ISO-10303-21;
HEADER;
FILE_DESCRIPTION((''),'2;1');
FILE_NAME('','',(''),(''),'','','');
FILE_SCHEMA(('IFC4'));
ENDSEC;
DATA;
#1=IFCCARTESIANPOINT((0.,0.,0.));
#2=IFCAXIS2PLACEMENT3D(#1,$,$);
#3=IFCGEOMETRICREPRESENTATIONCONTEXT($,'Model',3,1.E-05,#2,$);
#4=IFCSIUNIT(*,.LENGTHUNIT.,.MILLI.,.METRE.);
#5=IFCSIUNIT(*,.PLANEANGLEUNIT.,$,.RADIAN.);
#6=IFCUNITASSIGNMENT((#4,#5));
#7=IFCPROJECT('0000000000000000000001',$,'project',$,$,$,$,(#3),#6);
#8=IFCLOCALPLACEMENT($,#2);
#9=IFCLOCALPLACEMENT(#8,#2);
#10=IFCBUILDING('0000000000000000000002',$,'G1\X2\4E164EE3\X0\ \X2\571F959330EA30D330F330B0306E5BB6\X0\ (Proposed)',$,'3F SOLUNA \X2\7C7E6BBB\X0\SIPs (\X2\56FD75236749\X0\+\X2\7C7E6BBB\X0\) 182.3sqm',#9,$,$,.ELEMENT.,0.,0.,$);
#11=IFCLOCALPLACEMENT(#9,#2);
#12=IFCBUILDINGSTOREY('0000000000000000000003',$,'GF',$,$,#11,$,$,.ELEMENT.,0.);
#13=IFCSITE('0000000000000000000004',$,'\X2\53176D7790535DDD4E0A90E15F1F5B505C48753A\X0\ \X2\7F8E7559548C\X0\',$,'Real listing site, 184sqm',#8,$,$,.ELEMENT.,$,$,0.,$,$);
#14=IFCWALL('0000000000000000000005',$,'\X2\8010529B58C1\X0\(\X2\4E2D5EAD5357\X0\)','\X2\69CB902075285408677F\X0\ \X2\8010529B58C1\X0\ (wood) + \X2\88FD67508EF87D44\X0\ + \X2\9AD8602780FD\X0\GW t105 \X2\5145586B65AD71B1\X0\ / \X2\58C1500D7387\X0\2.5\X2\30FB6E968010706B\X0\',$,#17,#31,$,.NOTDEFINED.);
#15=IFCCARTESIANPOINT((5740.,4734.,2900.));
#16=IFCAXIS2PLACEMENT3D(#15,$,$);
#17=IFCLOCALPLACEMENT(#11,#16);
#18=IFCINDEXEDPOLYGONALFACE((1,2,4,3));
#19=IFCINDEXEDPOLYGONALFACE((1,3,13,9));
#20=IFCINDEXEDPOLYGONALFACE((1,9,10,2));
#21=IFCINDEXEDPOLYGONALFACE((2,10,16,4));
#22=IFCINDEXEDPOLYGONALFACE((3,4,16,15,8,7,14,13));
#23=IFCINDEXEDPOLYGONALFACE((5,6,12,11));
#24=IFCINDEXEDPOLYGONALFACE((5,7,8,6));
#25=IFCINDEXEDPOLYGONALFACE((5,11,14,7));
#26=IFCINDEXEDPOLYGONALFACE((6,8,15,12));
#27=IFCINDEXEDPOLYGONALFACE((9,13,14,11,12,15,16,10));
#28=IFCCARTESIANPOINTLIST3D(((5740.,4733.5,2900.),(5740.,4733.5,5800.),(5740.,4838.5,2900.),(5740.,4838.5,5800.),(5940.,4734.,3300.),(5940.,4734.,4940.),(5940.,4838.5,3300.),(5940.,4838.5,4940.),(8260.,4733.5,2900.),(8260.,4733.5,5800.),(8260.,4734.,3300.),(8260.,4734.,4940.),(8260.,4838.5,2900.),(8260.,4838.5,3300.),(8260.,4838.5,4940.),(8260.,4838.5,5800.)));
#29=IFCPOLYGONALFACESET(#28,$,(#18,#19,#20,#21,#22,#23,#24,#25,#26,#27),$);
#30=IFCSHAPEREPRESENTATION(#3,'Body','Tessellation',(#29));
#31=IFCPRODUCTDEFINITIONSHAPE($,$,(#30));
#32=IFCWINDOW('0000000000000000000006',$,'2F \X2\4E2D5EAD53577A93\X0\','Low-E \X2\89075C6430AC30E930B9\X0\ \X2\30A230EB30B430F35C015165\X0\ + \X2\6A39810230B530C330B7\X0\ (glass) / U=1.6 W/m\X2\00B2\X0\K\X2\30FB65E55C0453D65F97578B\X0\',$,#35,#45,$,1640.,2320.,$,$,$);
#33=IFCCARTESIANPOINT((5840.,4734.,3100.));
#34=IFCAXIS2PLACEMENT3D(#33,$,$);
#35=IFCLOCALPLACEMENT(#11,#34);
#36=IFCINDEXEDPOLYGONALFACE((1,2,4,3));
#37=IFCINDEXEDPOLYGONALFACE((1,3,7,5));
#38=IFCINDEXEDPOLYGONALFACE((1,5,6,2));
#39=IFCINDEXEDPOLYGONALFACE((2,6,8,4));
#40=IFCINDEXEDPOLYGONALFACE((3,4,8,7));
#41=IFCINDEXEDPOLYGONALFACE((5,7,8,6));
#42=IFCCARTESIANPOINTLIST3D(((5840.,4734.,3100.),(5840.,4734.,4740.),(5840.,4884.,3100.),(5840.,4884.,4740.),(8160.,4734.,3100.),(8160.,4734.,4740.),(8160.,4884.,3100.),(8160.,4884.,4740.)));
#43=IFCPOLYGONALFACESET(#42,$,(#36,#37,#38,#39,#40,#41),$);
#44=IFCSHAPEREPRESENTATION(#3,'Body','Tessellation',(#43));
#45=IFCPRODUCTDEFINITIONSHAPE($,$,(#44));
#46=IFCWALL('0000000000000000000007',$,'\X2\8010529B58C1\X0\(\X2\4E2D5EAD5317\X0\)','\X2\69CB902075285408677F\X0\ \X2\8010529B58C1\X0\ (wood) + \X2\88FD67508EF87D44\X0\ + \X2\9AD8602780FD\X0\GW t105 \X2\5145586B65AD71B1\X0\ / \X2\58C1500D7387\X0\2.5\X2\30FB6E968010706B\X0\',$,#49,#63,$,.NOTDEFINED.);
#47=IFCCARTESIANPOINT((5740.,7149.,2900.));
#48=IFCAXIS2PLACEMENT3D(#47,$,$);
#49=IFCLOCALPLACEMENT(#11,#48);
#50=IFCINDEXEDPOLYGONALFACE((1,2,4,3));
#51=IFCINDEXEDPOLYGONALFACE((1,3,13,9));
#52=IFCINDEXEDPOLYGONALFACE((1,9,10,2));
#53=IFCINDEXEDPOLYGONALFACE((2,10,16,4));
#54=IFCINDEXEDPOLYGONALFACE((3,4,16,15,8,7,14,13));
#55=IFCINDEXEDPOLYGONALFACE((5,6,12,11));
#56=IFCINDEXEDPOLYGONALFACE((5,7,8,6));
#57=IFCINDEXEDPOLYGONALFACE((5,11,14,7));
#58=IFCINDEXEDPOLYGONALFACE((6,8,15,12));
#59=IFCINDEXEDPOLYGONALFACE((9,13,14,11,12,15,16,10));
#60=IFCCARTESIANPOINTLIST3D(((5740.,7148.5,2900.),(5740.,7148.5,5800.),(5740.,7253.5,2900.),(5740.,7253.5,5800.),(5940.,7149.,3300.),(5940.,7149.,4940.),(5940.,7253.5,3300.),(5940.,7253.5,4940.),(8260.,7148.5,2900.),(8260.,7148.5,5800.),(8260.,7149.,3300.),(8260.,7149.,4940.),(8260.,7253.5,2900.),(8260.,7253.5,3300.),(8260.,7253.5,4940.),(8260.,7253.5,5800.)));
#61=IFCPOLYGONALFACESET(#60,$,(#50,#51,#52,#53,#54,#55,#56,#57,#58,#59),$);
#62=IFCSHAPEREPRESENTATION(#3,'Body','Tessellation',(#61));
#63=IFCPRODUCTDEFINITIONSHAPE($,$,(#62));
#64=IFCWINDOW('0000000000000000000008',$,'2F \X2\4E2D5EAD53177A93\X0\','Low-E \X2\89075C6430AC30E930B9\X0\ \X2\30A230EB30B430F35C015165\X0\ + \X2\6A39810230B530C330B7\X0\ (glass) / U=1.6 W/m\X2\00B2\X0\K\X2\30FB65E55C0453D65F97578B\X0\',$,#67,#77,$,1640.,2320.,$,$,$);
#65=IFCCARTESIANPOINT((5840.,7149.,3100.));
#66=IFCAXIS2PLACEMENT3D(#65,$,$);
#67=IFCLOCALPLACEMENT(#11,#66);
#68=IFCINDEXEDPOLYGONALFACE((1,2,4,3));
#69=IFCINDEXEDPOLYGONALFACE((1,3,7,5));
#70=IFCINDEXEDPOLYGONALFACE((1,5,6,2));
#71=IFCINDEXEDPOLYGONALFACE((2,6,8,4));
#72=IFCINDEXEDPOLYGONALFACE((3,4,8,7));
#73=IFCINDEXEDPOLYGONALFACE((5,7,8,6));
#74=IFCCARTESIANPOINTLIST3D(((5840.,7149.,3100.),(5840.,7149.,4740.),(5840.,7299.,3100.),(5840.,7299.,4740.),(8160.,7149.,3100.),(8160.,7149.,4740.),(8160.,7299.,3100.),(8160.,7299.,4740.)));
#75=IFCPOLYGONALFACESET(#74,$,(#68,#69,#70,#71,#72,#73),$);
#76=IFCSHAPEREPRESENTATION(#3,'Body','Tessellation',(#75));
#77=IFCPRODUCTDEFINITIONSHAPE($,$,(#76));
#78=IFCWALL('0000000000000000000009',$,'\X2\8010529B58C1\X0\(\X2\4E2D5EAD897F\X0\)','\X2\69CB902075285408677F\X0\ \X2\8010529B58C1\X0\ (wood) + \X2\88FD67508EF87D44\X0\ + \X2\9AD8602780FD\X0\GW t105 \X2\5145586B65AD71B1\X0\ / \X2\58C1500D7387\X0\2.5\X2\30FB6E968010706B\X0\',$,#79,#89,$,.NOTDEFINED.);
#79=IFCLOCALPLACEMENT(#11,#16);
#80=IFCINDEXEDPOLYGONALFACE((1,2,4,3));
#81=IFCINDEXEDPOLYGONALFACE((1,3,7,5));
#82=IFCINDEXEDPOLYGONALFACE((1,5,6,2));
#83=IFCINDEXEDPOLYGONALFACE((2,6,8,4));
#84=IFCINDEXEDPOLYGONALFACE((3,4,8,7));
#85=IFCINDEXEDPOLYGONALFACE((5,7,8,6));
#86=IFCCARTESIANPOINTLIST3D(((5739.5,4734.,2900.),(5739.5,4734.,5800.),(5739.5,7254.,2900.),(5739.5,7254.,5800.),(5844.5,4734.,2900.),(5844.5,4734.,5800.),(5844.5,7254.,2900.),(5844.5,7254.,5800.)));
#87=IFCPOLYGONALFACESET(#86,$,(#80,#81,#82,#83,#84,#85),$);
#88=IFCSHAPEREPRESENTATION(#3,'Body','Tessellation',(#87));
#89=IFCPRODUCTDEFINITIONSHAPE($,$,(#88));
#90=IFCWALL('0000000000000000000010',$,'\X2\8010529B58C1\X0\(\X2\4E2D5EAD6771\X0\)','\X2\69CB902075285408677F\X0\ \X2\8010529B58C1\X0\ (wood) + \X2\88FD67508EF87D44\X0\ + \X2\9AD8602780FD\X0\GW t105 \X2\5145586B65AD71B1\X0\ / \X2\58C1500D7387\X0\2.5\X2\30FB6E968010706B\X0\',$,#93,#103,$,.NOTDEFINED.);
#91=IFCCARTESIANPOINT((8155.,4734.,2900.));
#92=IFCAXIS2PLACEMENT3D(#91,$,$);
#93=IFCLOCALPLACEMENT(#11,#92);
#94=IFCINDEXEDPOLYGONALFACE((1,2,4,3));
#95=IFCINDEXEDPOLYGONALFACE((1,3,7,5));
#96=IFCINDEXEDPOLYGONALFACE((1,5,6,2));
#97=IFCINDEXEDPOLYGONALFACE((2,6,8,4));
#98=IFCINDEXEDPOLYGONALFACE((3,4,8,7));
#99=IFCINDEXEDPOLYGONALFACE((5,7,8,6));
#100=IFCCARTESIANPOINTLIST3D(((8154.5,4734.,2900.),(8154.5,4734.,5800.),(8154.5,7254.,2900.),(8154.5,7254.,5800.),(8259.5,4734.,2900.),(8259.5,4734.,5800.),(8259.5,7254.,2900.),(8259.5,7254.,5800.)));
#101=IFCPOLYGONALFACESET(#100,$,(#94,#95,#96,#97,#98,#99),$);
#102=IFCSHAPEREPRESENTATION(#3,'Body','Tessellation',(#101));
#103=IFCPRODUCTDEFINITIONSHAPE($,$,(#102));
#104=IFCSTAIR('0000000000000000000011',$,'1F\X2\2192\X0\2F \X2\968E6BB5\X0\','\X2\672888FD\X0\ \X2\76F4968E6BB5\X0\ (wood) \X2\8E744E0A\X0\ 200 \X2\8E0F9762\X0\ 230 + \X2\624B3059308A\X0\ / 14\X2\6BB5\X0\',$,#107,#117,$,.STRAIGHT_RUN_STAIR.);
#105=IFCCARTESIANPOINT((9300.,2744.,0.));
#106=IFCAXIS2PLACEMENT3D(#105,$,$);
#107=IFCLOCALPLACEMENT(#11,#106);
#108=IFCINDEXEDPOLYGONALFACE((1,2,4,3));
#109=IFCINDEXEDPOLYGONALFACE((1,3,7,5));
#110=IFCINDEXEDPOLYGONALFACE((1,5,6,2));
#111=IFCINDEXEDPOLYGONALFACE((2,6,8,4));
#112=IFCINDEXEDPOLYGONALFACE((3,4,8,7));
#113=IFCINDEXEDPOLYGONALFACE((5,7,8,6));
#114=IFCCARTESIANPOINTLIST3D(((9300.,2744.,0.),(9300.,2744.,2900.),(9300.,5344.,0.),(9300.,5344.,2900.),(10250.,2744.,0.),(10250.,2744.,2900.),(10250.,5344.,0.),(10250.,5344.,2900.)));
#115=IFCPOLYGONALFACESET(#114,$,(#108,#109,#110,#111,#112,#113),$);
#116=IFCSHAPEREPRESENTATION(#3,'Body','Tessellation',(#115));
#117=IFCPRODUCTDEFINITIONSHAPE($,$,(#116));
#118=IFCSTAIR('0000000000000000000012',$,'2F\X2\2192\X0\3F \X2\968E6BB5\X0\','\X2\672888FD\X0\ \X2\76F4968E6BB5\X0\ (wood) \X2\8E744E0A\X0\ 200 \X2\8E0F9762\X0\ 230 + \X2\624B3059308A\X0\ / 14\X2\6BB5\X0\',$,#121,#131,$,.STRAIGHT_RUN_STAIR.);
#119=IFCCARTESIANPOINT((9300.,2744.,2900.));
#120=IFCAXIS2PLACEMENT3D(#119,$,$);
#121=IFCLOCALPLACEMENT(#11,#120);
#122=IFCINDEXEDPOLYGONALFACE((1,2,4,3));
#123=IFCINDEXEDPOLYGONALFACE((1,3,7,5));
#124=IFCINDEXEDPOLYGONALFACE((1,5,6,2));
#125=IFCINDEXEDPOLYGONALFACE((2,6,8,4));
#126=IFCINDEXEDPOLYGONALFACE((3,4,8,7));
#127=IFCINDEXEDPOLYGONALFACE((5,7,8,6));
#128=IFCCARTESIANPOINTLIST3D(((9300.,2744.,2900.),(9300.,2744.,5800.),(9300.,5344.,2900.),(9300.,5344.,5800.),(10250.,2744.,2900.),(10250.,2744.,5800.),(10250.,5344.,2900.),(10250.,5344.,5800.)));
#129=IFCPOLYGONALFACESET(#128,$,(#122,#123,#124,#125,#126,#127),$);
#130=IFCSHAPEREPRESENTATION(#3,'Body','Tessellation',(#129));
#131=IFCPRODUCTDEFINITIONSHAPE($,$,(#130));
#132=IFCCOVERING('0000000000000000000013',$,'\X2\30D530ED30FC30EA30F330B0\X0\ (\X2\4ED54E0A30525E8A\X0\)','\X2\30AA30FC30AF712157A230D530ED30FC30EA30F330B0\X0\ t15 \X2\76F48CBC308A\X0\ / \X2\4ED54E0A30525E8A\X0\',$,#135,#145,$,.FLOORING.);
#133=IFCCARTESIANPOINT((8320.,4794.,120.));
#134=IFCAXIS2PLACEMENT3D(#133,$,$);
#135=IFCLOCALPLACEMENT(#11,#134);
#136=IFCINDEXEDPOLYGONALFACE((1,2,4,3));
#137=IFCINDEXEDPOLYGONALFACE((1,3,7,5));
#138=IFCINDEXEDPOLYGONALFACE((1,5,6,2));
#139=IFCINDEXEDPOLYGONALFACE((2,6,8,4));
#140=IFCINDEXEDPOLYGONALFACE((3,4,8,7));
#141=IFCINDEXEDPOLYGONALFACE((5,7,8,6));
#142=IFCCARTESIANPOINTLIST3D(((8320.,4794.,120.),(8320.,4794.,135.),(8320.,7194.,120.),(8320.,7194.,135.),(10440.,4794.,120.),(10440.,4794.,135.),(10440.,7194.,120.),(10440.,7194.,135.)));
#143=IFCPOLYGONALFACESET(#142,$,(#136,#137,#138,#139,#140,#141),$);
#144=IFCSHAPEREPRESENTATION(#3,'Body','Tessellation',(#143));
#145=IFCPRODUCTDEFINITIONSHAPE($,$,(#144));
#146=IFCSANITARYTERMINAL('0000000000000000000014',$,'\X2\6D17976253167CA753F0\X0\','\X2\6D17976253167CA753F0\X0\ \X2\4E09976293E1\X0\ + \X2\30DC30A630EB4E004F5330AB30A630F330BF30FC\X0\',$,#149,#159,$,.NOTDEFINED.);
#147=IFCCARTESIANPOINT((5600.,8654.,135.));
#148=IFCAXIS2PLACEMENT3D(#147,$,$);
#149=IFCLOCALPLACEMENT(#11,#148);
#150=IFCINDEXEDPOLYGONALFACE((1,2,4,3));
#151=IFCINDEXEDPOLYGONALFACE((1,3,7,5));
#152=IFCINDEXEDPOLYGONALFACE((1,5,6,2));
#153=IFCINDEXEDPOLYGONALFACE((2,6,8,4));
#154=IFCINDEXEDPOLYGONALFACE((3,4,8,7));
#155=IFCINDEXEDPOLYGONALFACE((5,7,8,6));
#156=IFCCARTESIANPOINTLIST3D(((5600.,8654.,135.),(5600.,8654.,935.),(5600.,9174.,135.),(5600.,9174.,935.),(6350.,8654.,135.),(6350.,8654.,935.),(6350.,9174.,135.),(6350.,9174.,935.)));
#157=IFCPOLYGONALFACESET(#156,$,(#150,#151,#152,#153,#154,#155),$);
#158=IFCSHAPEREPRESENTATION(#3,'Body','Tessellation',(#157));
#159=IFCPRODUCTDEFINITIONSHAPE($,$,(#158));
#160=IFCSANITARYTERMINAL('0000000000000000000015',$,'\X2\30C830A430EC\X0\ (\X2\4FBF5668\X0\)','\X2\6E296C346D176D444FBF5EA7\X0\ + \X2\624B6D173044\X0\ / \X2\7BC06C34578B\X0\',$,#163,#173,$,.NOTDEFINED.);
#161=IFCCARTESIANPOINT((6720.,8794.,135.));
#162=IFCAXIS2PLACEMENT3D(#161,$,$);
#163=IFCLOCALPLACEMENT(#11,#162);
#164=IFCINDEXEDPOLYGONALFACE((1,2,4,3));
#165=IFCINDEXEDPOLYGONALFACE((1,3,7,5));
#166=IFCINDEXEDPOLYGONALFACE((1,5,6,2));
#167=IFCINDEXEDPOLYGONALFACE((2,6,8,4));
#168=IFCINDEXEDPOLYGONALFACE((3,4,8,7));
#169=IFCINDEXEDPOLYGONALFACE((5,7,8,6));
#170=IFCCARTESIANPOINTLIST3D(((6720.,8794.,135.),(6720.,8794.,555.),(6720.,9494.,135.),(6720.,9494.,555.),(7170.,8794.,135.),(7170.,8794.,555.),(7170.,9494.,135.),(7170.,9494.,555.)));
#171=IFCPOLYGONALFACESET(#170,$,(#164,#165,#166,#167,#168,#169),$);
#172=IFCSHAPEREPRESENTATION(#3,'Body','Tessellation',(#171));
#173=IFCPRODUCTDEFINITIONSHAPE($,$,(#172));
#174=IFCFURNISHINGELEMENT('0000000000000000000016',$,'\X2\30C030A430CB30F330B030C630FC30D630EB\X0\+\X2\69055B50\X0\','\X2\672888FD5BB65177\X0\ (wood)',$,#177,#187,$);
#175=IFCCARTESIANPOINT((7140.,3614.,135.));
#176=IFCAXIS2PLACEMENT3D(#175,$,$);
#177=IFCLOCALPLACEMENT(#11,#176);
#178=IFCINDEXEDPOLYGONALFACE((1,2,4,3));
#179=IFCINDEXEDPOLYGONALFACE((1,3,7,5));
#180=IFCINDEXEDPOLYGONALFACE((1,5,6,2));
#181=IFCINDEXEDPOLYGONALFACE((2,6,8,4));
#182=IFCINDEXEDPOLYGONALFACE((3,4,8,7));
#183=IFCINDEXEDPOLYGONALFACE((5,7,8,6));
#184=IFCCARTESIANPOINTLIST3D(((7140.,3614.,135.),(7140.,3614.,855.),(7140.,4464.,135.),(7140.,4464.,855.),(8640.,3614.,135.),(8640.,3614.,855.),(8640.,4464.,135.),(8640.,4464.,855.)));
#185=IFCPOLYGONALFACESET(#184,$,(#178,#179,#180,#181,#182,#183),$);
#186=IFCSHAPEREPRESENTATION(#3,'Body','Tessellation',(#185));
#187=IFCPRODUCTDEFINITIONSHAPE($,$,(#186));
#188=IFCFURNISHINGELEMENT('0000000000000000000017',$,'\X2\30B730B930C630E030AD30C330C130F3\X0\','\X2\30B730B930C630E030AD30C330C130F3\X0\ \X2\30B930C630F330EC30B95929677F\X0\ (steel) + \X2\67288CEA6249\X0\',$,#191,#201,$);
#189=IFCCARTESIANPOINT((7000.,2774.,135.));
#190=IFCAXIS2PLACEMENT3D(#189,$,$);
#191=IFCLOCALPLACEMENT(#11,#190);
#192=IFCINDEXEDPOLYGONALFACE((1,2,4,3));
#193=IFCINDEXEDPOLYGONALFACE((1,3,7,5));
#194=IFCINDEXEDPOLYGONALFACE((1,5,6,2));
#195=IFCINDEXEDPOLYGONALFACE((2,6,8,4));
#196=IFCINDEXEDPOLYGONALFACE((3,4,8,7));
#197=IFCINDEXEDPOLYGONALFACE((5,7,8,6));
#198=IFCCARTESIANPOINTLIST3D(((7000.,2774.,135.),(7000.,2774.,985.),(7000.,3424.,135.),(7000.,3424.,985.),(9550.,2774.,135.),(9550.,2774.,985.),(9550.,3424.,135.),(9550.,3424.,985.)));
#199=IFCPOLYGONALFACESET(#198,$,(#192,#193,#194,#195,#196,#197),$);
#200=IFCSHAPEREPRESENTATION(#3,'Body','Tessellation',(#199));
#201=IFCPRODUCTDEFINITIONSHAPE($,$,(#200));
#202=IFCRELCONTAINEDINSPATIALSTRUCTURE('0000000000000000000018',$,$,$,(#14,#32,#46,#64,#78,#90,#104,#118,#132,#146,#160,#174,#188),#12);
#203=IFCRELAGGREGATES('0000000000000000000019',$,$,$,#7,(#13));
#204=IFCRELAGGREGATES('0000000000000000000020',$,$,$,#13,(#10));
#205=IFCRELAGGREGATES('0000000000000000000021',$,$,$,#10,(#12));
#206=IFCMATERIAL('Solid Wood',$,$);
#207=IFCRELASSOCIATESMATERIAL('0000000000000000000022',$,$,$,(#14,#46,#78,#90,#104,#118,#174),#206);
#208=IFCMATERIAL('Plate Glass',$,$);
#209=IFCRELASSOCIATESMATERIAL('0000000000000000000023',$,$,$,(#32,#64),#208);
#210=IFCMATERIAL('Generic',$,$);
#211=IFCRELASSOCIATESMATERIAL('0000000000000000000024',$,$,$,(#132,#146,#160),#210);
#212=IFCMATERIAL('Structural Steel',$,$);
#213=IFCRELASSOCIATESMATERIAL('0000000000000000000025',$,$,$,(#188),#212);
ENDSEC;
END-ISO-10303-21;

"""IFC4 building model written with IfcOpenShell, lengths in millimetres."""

from ifc_helpers import new_model, si_unit, frame, frame_2d, origin, place, context, project, spatial, rectangle, extrude, material, element, fill, save


model = new_model("IFC4")

# Units and contexts
model_context = context("Model", 3, precision=1e-05, world=origin())
ifc_project = project(units=[si_unit("LENGTHUNIT", "METRE", prefix="MILLI"), si_unit("PLANEANGLEUNIT", "RADIAN")], contexts=[model_context])

# Site, building, storey
site_placement = place(None, origin())
site = spatial("IfcSite", under=ifc_project, at=site_placement, Name="北海道川上郡弟子屈町 美留和", ObjectType="Real listing site, 184sqm", CompositionType="ELEMENT", RefElevation=0.0)
building_placement = place(site_placement, origin())
building = spatial("IfcBuilding", under=site, at=building_placement, Name="G1世代 土間リビングの家 (Proposed)", ObjectType="3F SOLUNA 籾殻SIPs (国産杉+籾殻) 182.3sqm", CompositionType="ELEMENT", ElevationOfRefHeight=0.0, ElevationOfTerrain=0.0)
storey_placement = place(building_placement, origin())
storey = spatial("IfcBuildingStorey", under=building, at=storey_placement, Name="GF", CompositionType="ELEMENT", Elevation=0.0)

# Shared definitions
ifc_material_1 = material(Name="Solid Wood")

# Shared definitions
ifc_material_2 = material(Name="Plate Glass")

# Walls, openings, windows
wall_1_placement = place(storey_placement, frame((5740.0, 4734.0, 2900.0)))
wall_1 = element("IfcWall", 1, at=wall_1_placement, inside=storey, material=ifc_material_1, Name="耐力壁(中庭南)", Description="構造用合板 耐力壁 (wood) + 製材軸組 + 高性能GW t105 充填断熱 / 壁倍率2.5・準耐火", PredefinedType="NOTDEFINED", context=model_context, shape_type="SweptSolid", body=[
    extrude(rectangle(XDim=2520.0, YDim=105.0, at=frame_2d((1260.0, 52.0))), frame((5740.0, 4734.0, 2900.0)), (0.0, 0.0, 1.0), 2900.0),
])
opening_1_placement = place(storey_placement, frame((5840.0, 4734.0, 3100.0)))
opening_1 = element("IfcOpeningElement", 2, at=opening_1_placement, cuts=wall_1, PredefinedType="NOTDEFINED", context=model_context, shape_type="SweptSolid", body=[
    extrude(rectangle(XDim=2320.0, YDim=150.0, at=frame_2d((1160.0, 75.0))), frame((5840.0, 4734.0, 3100.0)), (0.0, 0.0, 1.0), 1640.0),
])
window_1_placement = place(storey_placement, frame((5840.0, 4734.0, 3100.0)))
window_1 = element("IfcWindow", 3, at=window_1_placement, inside=storey, material=ifc_material_2, Name="2F 中庭南窓", Description="Low-E 複層ガラス アルゴン封入 + 樹脂サッシ (glass) / U=1.6 W/m²K・日射取得型", OverallHeight=1640.0, OverallWidth=2320.0, context=model_context, shape_type="SweptSolid", body=[
    extrude(rectangle(XDim=2320.0, YDim=150.0, at=frame_2d((1160.0, 75.0))), frame((5840.0, 4734.0, 3100.0)), (0.0, 0.0, 1.0), 1640.0),
])
fill(opening_1, window_1)
wall_2_placement = place(storey_placement, frame((5740.0, 7149.0, 2900.0)))
wall_2 = element("IfcWall", 4, at=wall_2_placement, inside=storey, material=ifc_material_1, Name="耐力壁(中庭北)", Description="構造用合板 耐力壁 (wood) + 製材軸組 + 高性能GW t105 充填断熱 / 壁倍率2.5・準耐火", PredefinedType="NOTDEFINED", context=model_context, shape_type="SweptSolid", body=[
    extrude(rectangle(XDim=2520.0, YDim=105.0, at=frame_2d((1260.0, 52.0))), frame((5740.0, 7149.0, 2900.0)), (0.0, 0.0, 1.0), 2900.0),
])
opening_2_placement = place(storey_placement, frame((5840.0, 7149.0, 3100.0)))
opening_2 = element("IfcOpeningElement", 5, at=opening_2_placement, cuts=wall_2, PredefinedType="NOTDEFINED", context=model_context, shape_type="SweptSolid", body=[
    extrude(rectangle(XDim=2320.0, YDim=150.0, at=frame_2d((1160.0, 75.0))), frame((5840.0, 7149.0, 3100.0)), (0.0, 0.0, 1.0), 1640.0),
])
window_2_placement = place(storey_placement, frame((5840.0, 7149.0, 3100.0)))
window_2 = element("IfcWindow", 6, at=window_2_placement, inside=storey, material=ifc_material_2, Name="2F 中庭北窓", Description="Low-E 複層ガラス アルゴン封入 + 樹脂サッシ (glass) / U=1.6 W/m²K・日射取得型", OverallHeight=1640.0, OverallWidth=2320.0, context=model_context, shape_type="SweptSolid", body=[
    extrude(rectangle(XDim=2320.0, YDim=150.0, at=frame_2d((1160.0, 75.0))), frame((5840.0, 7149.0, 3100.0)), (0.0, 0.0, 1.0), 1640.0),
])
fill(opening_2, window_2)

# Walls
wall_3_placement = place(storey_placement, frame((5740.0, 4734.0, 2900.0)))
element("IfcWall", 7, at=wall_3_placement, inside=storey, material=ifc_material_1, Name="耐力壁(中庭西)", Description="構造用合板 耐力壁 (wood) + 製材軸組 + 高性能GW t105 充填断熱 / 壁倍率2.5・準耐火", PredefinedType="NOTDEFINED", context=model_context, shape_type="SweptSolid", body=[
    extrude(rectangle(XDim=105.0, YDim=2520.0, at=frame_2d((52.0, 1260.0))), frame((5740.0, 4734.0, 2900.0)), (0.0, 0.0, 1.0), 2900.0),
])
wall_4_placement = place(storey_placement, frame((8155.0, 4734.0, 2900.0)))
element("IfcWall", 8, at=wall_4_placement, inside=storey, material=ifc_material_1, Name="耐力壁(中庭東)", Description="構造用合板 耐力壁 (wood) + 製材軸組 + 高性能GW t105 充填断熱 / 壁倍率2.5・準耐火", PredefinedType="NOTDEFINED", context=model_context, shape_type="SweptSolid", body=[
    extrude(rectangle(XDim=105.0, YDim=2520.0, at=frame_2d((52.0, 1260.0))), frame((8155.0, 4734.0, 2900.0)), (0.0, 0.0, 1.0), 2900.0),
])

# Stairs
stair_1_placement = place(storey_placement, frame((9300.0, 2744.0, 0.0)))
element("IfcStair", 9, at=stair_1_placement, inside=storey, material=ifc_material_1, Name="1F→2F 階段", Description="木製 直階段 (wood) 蹴上 200 踏面 230 + 手すり / 14段", PredefinedType="STRAIGHT_RUN_STAIR", context=model_context, shape_type="SweptSolid", body=[
    extrude(rectangle(XDim=950.0, YDim=2600.0, at=frame_2d((475.0, 1300.0))), frame((9300.0, 2744.0, 0.0)), (0.0, 0.0, 1.0), 2900.0),
])
stair_2_placement = place(storey_placement, frame((9300.0, 2744.0, 2900.0)))
element("IfcStair", 10, at=stair_2_placement, inside=storey, material=ifc_material_1, Name="2F→3F 階段", Description="木製 直階段 (wood) 蹴上 200 踏面 230 + 手すり / 14段", PredefinedType="STRAIGHT_RUN_STAIR", context=model_context, shape_type="SweptSolid", body=[
    extrude(rectangle(XDim=950.0, YDim=2600.0, at=frame_2d((475.0, 1300.0))), frame((9300.0, 2744.0, 2900.0)), (0.0, 0.0, 1.0), 2900.0),
])

# Covering
ifc_material_3 = material(Name="Generic")
covering_placement = place(storey_placement, frame((8320.0, 4794.0, 120.0)))
element("IfcCovering", 11, at=covering_placement, inside=storey, material=ifc_material_3, Name="フローリング (仕上げ床)", Description="オーク無垢フローリング t15 直貼り / 仕上げ床", PredefinedType="FLOORING", context=model_context, shape_type="SweptSolid", body=[
    extrude(rectangle(XDim=2120.0, YDim=2400.0, at=frame_2d((1060.0, 1200.0))), frame((8320.0, 4794.0, 120.0)), (0.0, 0.0, 1.0), 15.0),
])

# Sanitary terminals
sanitary_terminal_1_placement = place(storey_placement, frame((5600.0, 8654.0, 135.0)))
element("IfcSanitaryTerminal", 12, at=sanitary_terminal_1_placement, inside=storey, material=ifc_material_3, Name="洗面化粧台", Description="洗面化粧台 三面鏡 + ボウル一体カウンター", PredefinedType="NOTDEFINED", context=model_context, shape_type="SweptSolid", body=[
    extrude(rectangle(XDim=750.0, YDim=520.0, at=frame_2d((375.0, 260.0))), frame((5600.0, 8654.0, 135.0)), (0.0, 0.0, 1.0), 800.0),
])
sanitary_terminal_2_placement = place(storey_placement, frame((6720.0, 8794.0, 135.0)))
element("IfcSanitaryTerminal", 13, at=sanitary_terminal_2_placement, inside=storey, material=ifc_material_3, Name="トイレ (便器)", Description="温水洗浄便座 + 手洗い / 節水型", PredefinedType="NOTDEFINED", context=model_context, shape_type="SweptSolid", body=[
    extrude(rectangle(XDim=450.0, YDim=700.0, at=frame_2d((225.0, 350.0))), frame((6720.0, 8794.0, 135.0)), (0.0, 0.0, 1.0), 420.0),
])

# Furnishing elements
furnishing_1_placement = place(storey_placement, frame((7140.0, 3614.0, 135.0)))
element("IfcFurnishingElement", 14, at=furnishing_1_placement, inside=storey, material=ifc_material_1, Name="ダイニングテーブル+椅子", Description="木製家具 (wood)", context=model_context, shape_type="SweptSolid", body=[
    extrude(rectangle(XDim=1500.0, YDim=850.0, at=frame_2d((750.0, 425.0))), frame((7140.0, 3614.0, 135.0)), (0.0, 0.0, 1.0), 720.0),
])
ifc_material_4 = material(Name="Structural Steel")
furnishing_2_placement = place(storey_placement, frame((7000.0, 2774.0, 135.0)))
element("IfcFurnishingElement", 15, at=furnishing_2_placement, inside=storey, material=ifc_material_4, Name="システムキッチン", Description="システムキッチン ステンレス天板 (steel) + 木質扉", context=model_context, shape_type="SweptSolid", body=[
    extrude(rectangle(XDim=2550.0, YDim=650.0, at=frame_2d((1275.0, 325.0))), frame((7000.0, 2774.0, 135.0)), (0.0, 0.0, 1.0), 850.0),
])

save(model, "model.ifc")
